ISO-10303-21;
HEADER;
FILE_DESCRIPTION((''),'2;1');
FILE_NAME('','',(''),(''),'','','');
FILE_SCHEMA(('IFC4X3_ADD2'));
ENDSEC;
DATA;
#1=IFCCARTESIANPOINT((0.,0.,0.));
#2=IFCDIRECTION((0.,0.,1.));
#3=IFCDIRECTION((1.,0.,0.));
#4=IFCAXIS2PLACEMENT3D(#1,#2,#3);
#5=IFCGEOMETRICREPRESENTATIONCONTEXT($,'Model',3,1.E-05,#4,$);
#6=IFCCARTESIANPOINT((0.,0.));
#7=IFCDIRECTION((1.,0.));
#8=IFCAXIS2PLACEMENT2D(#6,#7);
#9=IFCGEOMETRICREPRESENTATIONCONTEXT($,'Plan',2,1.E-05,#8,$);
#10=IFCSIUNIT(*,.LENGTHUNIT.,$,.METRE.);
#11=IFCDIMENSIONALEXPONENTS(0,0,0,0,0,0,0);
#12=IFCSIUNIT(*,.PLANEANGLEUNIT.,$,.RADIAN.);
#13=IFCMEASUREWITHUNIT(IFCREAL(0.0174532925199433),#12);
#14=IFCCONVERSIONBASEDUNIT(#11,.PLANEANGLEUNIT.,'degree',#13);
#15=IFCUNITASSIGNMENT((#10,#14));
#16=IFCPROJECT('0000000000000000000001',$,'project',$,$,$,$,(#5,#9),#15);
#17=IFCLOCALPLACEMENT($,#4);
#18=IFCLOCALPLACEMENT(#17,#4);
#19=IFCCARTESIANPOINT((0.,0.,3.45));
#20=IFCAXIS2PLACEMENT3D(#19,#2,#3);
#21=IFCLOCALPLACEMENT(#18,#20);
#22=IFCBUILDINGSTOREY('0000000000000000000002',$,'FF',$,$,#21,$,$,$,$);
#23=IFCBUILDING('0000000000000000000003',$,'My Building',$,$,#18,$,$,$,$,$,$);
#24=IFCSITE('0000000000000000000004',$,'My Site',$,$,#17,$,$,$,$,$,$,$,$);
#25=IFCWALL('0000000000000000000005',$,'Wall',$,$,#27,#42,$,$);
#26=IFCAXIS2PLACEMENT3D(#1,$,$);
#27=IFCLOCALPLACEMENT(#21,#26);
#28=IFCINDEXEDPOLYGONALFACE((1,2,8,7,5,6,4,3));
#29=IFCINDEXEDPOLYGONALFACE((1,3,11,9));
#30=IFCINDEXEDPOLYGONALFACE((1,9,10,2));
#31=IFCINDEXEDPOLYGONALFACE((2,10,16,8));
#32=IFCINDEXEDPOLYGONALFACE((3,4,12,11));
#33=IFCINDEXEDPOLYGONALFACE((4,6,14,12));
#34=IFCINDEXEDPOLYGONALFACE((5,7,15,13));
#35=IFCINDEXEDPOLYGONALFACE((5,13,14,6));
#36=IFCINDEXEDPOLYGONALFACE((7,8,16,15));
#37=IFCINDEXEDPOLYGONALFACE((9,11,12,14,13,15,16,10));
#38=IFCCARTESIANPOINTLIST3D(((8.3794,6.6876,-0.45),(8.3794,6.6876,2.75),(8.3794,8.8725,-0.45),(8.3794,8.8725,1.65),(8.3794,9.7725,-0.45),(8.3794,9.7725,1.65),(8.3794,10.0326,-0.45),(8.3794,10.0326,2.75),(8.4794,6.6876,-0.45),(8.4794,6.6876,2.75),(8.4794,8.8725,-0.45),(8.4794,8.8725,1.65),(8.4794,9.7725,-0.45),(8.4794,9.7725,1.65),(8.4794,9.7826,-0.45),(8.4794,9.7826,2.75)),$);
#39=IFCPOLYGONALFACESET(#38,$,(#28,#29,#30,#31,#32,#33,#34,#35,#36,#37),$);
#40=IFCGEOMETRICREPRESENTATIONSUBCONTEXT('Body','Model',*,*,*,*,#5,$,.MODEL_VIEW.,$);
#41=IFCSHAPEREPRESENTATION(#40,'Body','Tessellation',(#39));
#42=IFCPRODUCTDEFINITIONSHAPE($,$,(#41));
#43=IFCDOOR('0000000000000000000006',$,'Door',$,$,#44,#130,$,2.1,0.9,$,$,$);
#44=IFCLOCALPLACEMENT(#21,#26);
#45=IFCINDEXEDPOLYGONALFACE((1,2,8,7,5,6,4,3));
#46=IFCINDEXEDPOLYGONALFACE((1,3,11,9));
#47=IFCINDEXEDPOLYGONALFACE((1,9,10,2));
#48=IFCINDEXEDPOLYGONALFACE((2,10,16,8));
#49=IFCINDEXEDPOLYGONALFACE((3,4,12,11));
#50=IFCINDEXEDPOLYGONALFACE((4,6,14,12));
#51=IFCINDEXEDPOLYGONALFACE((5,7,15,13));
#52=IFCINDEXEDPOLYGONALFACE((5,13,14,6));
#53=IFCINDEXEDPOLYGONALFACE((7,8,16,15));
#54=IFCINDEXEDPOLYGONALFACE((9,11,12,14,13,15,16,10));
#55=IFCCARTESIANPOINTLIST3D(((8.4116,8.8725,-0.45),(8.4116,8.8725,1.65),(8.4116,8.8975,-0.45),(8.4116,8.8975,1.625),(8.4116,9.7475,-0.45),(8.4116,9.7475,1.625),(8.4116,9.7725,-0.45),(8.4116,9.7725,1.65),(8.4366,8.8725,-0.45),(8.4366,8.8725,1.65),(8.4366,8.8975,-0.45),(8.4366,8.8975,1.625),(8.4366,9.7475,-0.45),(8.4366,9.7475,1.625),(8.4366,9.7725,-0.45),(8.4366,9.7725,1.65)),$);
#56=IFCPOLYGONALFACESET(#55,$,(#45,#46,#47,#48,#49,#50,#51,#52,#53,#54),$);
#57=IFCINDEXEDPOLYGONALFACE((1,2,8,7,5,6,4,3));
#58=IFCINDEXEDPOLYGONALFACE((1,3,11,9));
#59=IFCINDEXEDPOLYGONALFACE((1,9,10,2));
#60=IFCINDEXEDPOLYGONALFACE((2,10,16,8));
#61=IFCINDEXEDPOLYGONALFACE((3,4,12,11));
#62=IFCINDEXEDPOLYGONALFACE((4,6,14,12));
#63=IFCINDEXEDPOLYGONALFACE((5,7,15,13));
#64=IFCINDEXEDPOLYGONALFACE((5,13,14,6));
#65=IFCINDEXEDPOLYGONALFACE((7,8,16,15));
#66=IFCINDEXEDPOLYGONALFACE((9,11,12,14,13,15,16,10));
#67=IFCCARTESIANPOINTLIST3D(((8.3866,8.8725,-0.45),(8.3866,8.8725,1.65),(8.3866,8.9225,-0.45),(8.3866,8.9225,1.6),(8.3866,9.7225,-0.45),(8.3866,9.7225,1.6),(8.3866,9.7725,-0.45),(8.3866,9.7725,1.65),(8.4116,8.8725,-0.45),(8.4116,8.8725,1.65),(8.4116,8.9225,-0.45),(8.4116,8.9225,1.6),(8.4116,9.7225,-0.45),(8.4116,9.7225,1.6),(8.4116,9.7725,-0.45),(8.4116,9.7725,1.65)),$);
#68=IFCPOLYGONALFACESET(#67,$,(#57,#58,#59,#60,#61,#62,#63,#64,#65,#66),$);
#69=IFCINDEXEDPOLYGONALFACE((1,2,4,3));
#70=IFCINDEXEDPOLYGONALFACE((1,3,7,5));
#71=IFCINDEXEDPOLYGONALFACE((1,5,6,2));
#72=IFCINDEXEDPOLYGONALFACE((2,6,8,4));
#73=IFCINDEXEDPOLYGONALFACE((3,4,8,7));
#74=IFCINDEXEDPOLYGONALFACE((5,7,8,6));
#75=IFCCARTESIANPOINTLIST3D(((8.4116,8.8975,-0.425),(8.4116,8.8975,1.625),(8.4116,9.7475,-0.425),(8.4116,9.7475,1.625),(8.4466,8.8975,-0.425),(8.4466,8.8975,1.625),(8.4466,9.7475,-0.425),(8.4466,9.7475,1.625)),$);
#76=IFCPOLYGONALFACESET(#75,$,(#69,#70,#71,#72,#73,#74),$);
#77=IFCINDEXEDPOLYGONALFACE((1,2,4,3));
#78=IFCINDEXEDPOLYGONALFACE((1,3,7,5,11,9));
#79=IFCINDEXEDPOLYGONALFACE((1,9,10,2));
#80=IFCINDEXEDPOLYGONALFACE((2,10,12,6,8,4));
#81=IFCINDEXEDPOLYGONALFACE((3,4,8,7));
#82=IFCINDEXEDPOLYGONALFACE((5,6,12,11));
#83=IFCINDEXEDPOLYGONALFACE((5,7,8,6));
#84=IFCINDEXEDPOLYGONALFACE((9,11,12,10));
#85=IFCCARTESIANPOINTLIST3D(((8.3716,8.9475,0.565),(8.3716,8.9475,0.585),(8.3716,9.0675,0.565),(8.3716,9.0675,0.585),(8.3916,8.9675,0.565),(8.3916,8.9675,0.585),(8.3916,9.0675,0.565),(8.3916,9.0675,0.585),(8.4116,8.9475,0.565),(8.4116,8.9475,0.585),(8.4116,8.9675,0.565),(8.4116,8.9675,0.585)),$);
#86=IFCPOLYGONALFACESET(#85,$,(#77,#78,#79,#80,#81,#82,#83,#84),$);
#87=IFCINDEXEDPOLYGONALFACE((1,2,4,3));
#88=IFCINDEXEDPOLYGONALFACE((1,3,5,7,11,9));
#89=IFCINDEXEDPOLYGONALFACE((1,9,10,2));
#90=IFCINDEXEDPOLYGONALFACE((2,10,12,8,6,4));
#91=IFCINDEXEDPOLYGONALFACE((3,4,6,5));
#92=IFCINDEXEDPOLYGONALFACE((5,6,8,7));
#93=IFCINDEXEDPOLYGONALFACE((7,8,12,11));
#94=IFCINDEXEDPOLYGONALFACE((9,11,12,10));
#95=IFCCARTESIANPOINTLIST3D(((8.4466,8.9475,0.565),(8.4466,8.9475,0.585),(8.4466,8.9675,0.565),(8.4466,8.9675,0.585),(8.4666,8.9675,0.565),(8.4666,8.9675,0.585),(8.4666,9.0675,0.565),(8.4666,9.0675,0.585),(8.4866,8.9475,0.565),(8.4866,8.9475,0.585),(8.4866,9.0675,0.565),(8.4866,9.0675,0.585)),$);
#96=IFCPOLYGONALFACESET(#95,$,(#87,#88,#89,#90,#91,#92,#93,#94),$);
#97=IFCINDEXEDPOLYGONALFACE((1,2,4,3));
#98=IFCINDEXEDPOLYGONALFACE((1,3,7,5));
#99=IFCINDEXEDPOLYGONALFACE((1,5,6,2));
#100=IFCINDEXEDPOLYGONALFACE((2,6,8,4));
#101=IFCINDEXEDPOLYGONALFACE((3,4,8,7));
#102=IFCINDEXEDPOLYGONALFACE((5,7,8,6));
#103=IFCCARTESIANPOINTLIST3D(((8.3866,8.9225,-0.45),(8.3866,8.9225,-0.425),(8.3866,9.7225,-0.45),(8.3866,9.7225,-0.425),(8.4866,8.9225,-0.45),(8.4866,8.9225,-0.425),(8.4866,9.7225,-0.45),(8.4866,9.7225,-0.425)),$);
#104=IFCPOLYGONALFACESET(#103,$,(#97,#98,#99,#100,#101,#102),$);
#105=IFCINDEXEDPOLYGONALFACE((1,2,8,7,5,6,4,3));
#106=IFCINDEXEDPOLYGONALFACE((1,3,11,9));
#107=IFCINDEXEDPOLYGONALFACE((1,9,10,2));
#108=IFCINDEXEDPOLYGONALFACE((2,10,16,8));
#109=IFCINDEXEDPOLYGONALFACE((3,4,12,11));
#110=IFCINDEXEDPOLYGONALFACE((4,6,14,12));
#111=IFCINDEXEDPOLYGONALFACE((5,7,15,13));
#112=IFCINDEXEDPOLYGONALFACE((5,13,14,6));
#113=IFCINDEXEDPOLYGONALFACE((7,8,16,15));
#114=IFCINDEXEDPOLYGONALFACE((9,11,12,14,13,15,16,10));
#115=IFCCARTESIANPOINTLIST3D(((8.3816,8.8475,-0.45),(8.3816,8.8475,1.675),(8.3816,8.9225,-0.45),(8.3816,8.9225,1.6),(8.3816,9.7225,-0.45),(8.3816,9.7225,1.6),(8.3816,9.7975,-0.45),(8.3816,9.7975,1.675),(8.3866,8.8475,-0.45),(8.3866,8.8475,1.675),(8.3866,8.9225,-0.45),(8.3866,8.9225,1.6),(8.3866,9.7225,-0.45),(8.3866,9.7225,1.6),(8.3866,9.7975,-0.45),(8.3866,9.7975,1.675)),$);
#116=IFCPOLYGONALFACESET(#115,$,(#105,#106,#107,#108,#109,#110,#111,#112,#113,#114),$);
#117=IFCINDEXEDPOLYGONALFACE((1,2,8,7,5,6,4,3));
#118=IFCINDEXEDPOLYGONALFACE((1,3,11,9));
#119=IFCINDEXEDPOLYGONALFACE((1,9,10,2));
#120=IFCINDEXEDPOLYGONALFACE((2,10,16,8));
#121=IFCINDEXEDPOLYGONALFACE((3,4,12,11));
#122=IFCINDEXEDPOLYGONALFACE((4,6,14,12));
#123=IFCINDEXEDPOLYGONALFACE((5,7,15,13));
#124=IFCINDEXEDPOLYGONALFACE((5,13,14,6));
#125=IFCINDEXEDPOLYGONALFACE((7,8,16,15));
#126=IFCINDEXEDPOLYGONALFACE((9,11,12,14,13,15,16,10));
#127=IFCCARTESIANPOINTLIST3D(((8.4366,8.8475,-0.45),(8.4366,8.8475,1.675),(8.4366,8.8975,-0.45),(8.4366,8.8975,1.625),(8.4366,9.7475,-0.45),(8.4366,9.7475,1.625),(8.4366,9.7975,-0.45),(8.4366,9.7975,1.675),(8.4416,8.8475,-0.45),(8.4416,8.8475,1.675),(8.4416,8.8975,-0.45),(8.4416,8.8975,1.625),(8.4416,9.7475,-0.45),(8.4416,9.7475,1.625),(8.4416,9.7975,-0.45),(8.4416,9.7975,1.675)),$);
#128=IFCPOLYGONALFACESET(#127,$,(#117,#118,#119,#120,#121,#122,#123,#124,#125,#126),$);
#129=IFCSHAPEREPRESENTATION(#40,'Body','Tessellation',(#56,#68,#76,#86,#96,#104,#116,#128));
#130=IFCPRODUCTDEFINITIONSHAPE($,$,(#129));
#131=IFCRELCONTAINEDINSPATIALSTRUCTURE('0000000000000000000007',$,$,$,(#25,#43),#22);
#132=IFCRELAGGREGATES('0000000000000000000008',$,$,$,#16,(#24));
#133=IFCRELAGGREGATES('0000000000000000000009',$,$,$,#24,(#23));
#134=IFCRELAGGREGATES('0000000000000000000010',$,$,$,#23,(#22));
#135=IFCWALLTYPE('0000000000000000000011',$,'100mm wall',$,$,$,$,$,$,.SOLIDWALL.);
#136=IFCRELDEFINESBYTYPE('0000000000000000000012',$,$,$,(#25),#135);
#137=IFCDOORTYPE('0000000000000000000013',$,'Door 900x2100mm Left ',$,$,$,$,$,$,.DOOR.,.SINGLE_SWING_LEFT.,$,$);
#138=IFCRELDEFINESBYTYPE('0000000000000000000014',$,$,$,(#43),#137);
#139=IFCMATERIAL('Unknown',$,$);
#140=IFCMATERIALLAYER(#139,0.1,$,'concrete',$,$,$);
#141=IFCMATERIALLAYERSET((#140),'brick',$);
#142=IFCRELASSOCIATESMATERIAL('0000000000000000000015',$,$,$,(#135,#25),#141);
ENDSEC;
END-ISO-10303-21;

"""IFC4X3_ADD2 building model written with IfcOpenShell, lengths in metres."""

from ifc_helpers import new_model, entity, si_unit, converted_unit, frame, origin_with_axes, origin_2d_with_axis, place, context, subcontext, project, spatial, line, indexed_curve, outline, extrude, shape, source, transform, mapped, material, layer, layer_set, layer_usage, type_object, type_shapes, element, fill, save


model = new_model("IFC4X3_ADD2")

# Units and contexts
model_context = context("Model", 3, precision=1e-05, world=origin_with_axes())
plan_context = context("Plan", 2, precision=1e-05, world=origin_2d_with_axis())
body_context_1 = subcontext(model_context, "Body", "Model", "MODEL_VIEW")
body_context_2 = subcontext(plan_context, "Body", "Plan", "PLAN_VIEW")
ifc_project = project(units=[si_unit("LENGTHUNIT", "METRE"), converted_unit("PLANEANGLEUNIT", "degree", entity("IfcReal", 0.0174532925199433), si_unit("PLANEANGLEUNIT", "RADIAN"), dimensions=[0, 0, 0, 0, 0, 0, 0])], contexts=[model_context, plan_context])

# Site, building, storey
site_placement = place(None, origin_with_axes())
site = spatial("IfcSite", under=ifc_project, at=site_placement, Name="My Site")
building_placement = place(site_placement, origin_with_axes())
building = spatial("IfcBuilding", under=site, at=building_placement, Name="My Building")
storey_placement = place(building_placement, frame((0.0, 0.0, 3.45), z_axis=(0.0, 0.0, 1.0), x_axis=(1.0, 0.0, 0.0)))
storey = spatial("IfcBuildingStorey", under=building, at=storey_placement, Name="FF")

# Shared definitions
ifc_material = material(Name="Unknown")

# Wall, opening, door
ifc_layer_1 = layer(ifc_material, 0.1, Name="concrete")
ifc_layer_set_1 = layer_set([ifc_layer_1], Name="brick")
ifc_layer_usage_1 = layer_usage(ifc_layer_set_1, "AXIS2", "POSITIVE", 0.0)
wall_type_1 = type_object("IfcWallType", Name="100mm wall", PredefinedType="SOLIDWALL", material=ifc_layer_set_1)
wall_1_placement = place(storey_placement, frame((8.4794, 6.6876, -0.45), z_axis=(0.0, 0.0, 1.0), x_axis=(0.0, 1.0, 0.0)))
wall_1 = element("IfcWall", 1, at=wall_1_placement, inside=storey, type_object=wall_type_1, material=ifc_layer_usage_1, Name="Wall", context=body_context_1, shape_type="SweptSolid", body=[
    extrude(outline(indexed_curve([(0.0, 0.0), (0.0, 0.1), (3.345, 0.1), (3.095, 0.0)], segments=[line(1, 2, 3, 4, 1)])), origin_with_axes(), (0.0, 0.0, 1.0), 3.2),
])
shared_shape_1 = source(origin_with_axes(), body_context_1, "Body", "SweptSolid", [
    extrude(outline(indexed_curve([(0.0, 0.0), (0.9, 0.0), (0.9, 2.1), (0.0, 2.1)], segments=[line(1, 2, 3, 4, 1)])), frame((0.0, -0.6, 0.0), z_axis=(0.0, -1.0, 0.0), x_axis=(1.0, 0.0, 0.0)), (0.0, 0.0, -1.0), 1.2),
])
opening_1_placement = place(wall_1_placement, frame((3.0849, 0.0928, 0.0), z_axis=(0.0, 0.0, 1.0), x_axis=(-1.0, 0.0, 0.0)))
opening_1 = element("IfcOpeningElement", 2, at=opening_1_placement, cuts=wall_1, PredefinedType="OPENING", context=body_context_1, shape_type="MappedRepresentation", body=[
    mapped(shared_shape_1, transform((0.0, 0.0, 0.0), x_axis=(1.0, 0.0, 0.0), y_axis=(0.0, 1.0, 0.0), z_axis=(0.0, 0.0, 1.0), scale=1.0)),
])
door_type_1 = type_object("IfcDoorType", Name="Door 900x2100mm Left ", OperationType="SINGLE_SWING_LEFT", PredefinedType="DOOR")
shared_shape_2 = source(origin_with_axes(), body_context_1, "Body", "SweptSolid", [
    extrude(outline(indexed_curve([(0.0, 0.0), (0.0, 2.1), (0.9, 2.1), (0.9, 0.0), (0.875, 0.0), (0.875, 2.075), (0.025, 2.075), (0.025, 0.0)], segments=[line(1, 2, 3, 4, 5, 6, 7, 8, 1)])), frame((0.0, 0.025, 0.0), z_axis=(0.0, -1.0, 0.0), x_axis=(1.0, 0.0, 0.0)), (0.0, 0.0, -1.0), 0.025),
    extrude(outline(indexed_curve([(0.0, 0.0), (0.0, 2.1), (0.9, 2.1), (0.9, 0.0), (0.85, 0.0), (0.85, 2.05), (0.05, 2.05), (0.05, 0.0)], segments=[line(1, 2, 3, 4, 5, 6, 7, 8, 1)])), frame((0.0, 0.0, 0.0), z_axis=(0.0, -1.0, 0.0), x_axis=(1.0, 0.0, 0.0)), (0.0, 0.0, -1.0), 0.025),
    extrude(outline(indexed_curve([(0.0, 0.0), (0.85, 0.0), (0.85, 0.035), (0.0, 0.035)], segments=[line(1, 2, 3, 4, 1)])), frame((0.025, 0.025, 0.025), z_axis=(0.0, 0.0, 1.0), x_axis=(1.0, 0.0, 0.0)), (0.0, 0.0, 1.0), 2.05),
    extrude(outline(indexed_curve([(0.0, 0.0), (0.0, -0.04), (-0.12, -0.04), (-0.12, -0.02), (-0.02, -0.02), (-0.02, 0.0)], segments=[line(1, 2, 3, 4, 5, 6, 1)])), frame((0.825, 0.025, 1.015), z_axis=(0.0, 0.0, 1.0), x_axis=(1.0, 0.0, 0.0)), (0.0, 0.0, 1.0), 0.02),
    extrude(outline(indexed_curve([(0.0, 0.0), (0.0, 0.04), (-0.12, 0.04), (-0.12, 0.02), (-0.02, 0.02), (-0.02, 0.0)], segments=[line(1, 2, 3, 4, 5, 6, 1)])), frame((0.825, 0.06, 1.015), z_axis=(0.0, 0.0, 1.0), x_axis=(1.0, 0.0, 0.0)), (0.0, 0.0, 1.0), 0.02),
    extrude(outline(indexed_curve([(0.0, 0.0), (0.8, 0.0), (0.8, 0.1), (0.0, 0.1)], segments=[line(1, 2, 3, 4, 1)])), frame((0.05, 0.0, 0.0), z_axis=(0.0, 0.0, 1.0), x_axis=(1.0, 0.0, 0.0)), (0.0, 0.0, 1.0), 0.025),
    extrude(outline(indexed_curve([(0.0, 0.0), (0.0, 2.125), (0.95, 2.125), (0.95, 0.0), (0.875, 0.0), (0.875, 2.05), (0.075, 2.05), (0.075, 0.0)], segments=[line(1, 2, 3, 4, 5, 6, 7, 8, 1)])), frame((-0.025, -0.005, 0.0), z_axis=(0.0, -1.0, 0.0), x_axis=(1.0, 0.0, 0.0)), (0.0, 0.0, -1.0), 0.005),
    extrude(outline(indexed_curve([(0.0, 0.0), (0.0, 2.125), (0.95, 2.125), (0.95, 0.0), (0.9, 0.0), (0.9, 2.075), (0.05, 2.075), (0.05, 0.0)], segments=[line(1, 2, 3, 4, 5, 6, 7, 8, 1)])), frame((-0.025, 0.05, 0.0), z_axis=(0.0, -1.0, 0.0), x_axis=(1.0, 0.0, 0.0)), (0.0, 0.0, -1.0), 0.005),
])
shared_shape_3 = source(origin_with_axes(), body_context_2, "Body", "Curve2D", [
    entity("IfcIndexedPolyCurve", entity("IfcCartesianPointList2D", [[0.0, 0.0], [0.0, 0.05], [0.025, 0.05], [0.025, 0.025], [0.05, 0.025], [0.05, 0.0]]), [entity("IfcLineIndex", [1, 2, 3, 4, 5, 6, 1])]),
    entity("IfcIndexedPolyCurve", entity("IfcCartesianPointList2D", [[0.9, 0.0], [0.9, 0.05], [0.875, 0.05], [0.875, 0.025], [0.85, 0.025], [0.85, 0.0]]), [entity("IfcLineIndex", [1, 2, 3, 4, 5, 6, 1])]),
    entity("IfcTrimmedCurve", entity("IfcEllipse", entity("IfcAxis2Placement2D", entity("IfcCartesianPoint", [0.06, 0.05]), entity("IfcDirection", [1.0, 0.0])), 0.815, 0.85), [entity("IfcCartesianPoint", [0.875, 0.05])], [entity("IfcCartesianPoint", [0.06, 0.9])], True, "CARTESIAN"),
    entity("IfcIndexedPolyCurve", entity("IfcCartesianPointList2D", [[0.025, 0.05], [0.06, 0.05], [0.06, 0.9], [0.025, 0.9]]), [entity("IfcLineIndex", [1, 2, 3, 4, 1])]),
])
type_shapes(door_type_1, [shared_shape_2, shared_shape_3])
door_1_placement = place(opening_1_placement, frame((0.0, 0.0, 0.0), z_axis=(0.0, 0.0, 1.0), x_axis=(1.0, 0.0, 0.0)))
door_1 = element("IfcDoor", 3, at=door_1_placement, inside=storey, type_object=door_type_1, Name="Door", OverallHeight=2.1, OverallWidth=0.9, shapes=[
    shape(body_context_1, "Body", "MappedRepresentation", [mapped(shared_shape_2, transform((0.0, 0.0, 0.0), x_axis=(1.0, 0.0, 0.0), y_axis=(0.0, 1.0, 0.0), z_axis=(0.0, 0.0, 1.0), scale=1.0))]),
    shape(body_context_2, "Body", "MappedRepresentation", [mapped(shared_shape_3, transform((0.0, 0.0, 0.0), x_axis=(1.0, 0.0, 0.0), y_axis=(0.0, 1.0, 0.0), z_axis=(0.0, 0.0, 1.0), scale=1.0))]),
])
fill(opening_1, door_1)

save(model, "model.ifc")
